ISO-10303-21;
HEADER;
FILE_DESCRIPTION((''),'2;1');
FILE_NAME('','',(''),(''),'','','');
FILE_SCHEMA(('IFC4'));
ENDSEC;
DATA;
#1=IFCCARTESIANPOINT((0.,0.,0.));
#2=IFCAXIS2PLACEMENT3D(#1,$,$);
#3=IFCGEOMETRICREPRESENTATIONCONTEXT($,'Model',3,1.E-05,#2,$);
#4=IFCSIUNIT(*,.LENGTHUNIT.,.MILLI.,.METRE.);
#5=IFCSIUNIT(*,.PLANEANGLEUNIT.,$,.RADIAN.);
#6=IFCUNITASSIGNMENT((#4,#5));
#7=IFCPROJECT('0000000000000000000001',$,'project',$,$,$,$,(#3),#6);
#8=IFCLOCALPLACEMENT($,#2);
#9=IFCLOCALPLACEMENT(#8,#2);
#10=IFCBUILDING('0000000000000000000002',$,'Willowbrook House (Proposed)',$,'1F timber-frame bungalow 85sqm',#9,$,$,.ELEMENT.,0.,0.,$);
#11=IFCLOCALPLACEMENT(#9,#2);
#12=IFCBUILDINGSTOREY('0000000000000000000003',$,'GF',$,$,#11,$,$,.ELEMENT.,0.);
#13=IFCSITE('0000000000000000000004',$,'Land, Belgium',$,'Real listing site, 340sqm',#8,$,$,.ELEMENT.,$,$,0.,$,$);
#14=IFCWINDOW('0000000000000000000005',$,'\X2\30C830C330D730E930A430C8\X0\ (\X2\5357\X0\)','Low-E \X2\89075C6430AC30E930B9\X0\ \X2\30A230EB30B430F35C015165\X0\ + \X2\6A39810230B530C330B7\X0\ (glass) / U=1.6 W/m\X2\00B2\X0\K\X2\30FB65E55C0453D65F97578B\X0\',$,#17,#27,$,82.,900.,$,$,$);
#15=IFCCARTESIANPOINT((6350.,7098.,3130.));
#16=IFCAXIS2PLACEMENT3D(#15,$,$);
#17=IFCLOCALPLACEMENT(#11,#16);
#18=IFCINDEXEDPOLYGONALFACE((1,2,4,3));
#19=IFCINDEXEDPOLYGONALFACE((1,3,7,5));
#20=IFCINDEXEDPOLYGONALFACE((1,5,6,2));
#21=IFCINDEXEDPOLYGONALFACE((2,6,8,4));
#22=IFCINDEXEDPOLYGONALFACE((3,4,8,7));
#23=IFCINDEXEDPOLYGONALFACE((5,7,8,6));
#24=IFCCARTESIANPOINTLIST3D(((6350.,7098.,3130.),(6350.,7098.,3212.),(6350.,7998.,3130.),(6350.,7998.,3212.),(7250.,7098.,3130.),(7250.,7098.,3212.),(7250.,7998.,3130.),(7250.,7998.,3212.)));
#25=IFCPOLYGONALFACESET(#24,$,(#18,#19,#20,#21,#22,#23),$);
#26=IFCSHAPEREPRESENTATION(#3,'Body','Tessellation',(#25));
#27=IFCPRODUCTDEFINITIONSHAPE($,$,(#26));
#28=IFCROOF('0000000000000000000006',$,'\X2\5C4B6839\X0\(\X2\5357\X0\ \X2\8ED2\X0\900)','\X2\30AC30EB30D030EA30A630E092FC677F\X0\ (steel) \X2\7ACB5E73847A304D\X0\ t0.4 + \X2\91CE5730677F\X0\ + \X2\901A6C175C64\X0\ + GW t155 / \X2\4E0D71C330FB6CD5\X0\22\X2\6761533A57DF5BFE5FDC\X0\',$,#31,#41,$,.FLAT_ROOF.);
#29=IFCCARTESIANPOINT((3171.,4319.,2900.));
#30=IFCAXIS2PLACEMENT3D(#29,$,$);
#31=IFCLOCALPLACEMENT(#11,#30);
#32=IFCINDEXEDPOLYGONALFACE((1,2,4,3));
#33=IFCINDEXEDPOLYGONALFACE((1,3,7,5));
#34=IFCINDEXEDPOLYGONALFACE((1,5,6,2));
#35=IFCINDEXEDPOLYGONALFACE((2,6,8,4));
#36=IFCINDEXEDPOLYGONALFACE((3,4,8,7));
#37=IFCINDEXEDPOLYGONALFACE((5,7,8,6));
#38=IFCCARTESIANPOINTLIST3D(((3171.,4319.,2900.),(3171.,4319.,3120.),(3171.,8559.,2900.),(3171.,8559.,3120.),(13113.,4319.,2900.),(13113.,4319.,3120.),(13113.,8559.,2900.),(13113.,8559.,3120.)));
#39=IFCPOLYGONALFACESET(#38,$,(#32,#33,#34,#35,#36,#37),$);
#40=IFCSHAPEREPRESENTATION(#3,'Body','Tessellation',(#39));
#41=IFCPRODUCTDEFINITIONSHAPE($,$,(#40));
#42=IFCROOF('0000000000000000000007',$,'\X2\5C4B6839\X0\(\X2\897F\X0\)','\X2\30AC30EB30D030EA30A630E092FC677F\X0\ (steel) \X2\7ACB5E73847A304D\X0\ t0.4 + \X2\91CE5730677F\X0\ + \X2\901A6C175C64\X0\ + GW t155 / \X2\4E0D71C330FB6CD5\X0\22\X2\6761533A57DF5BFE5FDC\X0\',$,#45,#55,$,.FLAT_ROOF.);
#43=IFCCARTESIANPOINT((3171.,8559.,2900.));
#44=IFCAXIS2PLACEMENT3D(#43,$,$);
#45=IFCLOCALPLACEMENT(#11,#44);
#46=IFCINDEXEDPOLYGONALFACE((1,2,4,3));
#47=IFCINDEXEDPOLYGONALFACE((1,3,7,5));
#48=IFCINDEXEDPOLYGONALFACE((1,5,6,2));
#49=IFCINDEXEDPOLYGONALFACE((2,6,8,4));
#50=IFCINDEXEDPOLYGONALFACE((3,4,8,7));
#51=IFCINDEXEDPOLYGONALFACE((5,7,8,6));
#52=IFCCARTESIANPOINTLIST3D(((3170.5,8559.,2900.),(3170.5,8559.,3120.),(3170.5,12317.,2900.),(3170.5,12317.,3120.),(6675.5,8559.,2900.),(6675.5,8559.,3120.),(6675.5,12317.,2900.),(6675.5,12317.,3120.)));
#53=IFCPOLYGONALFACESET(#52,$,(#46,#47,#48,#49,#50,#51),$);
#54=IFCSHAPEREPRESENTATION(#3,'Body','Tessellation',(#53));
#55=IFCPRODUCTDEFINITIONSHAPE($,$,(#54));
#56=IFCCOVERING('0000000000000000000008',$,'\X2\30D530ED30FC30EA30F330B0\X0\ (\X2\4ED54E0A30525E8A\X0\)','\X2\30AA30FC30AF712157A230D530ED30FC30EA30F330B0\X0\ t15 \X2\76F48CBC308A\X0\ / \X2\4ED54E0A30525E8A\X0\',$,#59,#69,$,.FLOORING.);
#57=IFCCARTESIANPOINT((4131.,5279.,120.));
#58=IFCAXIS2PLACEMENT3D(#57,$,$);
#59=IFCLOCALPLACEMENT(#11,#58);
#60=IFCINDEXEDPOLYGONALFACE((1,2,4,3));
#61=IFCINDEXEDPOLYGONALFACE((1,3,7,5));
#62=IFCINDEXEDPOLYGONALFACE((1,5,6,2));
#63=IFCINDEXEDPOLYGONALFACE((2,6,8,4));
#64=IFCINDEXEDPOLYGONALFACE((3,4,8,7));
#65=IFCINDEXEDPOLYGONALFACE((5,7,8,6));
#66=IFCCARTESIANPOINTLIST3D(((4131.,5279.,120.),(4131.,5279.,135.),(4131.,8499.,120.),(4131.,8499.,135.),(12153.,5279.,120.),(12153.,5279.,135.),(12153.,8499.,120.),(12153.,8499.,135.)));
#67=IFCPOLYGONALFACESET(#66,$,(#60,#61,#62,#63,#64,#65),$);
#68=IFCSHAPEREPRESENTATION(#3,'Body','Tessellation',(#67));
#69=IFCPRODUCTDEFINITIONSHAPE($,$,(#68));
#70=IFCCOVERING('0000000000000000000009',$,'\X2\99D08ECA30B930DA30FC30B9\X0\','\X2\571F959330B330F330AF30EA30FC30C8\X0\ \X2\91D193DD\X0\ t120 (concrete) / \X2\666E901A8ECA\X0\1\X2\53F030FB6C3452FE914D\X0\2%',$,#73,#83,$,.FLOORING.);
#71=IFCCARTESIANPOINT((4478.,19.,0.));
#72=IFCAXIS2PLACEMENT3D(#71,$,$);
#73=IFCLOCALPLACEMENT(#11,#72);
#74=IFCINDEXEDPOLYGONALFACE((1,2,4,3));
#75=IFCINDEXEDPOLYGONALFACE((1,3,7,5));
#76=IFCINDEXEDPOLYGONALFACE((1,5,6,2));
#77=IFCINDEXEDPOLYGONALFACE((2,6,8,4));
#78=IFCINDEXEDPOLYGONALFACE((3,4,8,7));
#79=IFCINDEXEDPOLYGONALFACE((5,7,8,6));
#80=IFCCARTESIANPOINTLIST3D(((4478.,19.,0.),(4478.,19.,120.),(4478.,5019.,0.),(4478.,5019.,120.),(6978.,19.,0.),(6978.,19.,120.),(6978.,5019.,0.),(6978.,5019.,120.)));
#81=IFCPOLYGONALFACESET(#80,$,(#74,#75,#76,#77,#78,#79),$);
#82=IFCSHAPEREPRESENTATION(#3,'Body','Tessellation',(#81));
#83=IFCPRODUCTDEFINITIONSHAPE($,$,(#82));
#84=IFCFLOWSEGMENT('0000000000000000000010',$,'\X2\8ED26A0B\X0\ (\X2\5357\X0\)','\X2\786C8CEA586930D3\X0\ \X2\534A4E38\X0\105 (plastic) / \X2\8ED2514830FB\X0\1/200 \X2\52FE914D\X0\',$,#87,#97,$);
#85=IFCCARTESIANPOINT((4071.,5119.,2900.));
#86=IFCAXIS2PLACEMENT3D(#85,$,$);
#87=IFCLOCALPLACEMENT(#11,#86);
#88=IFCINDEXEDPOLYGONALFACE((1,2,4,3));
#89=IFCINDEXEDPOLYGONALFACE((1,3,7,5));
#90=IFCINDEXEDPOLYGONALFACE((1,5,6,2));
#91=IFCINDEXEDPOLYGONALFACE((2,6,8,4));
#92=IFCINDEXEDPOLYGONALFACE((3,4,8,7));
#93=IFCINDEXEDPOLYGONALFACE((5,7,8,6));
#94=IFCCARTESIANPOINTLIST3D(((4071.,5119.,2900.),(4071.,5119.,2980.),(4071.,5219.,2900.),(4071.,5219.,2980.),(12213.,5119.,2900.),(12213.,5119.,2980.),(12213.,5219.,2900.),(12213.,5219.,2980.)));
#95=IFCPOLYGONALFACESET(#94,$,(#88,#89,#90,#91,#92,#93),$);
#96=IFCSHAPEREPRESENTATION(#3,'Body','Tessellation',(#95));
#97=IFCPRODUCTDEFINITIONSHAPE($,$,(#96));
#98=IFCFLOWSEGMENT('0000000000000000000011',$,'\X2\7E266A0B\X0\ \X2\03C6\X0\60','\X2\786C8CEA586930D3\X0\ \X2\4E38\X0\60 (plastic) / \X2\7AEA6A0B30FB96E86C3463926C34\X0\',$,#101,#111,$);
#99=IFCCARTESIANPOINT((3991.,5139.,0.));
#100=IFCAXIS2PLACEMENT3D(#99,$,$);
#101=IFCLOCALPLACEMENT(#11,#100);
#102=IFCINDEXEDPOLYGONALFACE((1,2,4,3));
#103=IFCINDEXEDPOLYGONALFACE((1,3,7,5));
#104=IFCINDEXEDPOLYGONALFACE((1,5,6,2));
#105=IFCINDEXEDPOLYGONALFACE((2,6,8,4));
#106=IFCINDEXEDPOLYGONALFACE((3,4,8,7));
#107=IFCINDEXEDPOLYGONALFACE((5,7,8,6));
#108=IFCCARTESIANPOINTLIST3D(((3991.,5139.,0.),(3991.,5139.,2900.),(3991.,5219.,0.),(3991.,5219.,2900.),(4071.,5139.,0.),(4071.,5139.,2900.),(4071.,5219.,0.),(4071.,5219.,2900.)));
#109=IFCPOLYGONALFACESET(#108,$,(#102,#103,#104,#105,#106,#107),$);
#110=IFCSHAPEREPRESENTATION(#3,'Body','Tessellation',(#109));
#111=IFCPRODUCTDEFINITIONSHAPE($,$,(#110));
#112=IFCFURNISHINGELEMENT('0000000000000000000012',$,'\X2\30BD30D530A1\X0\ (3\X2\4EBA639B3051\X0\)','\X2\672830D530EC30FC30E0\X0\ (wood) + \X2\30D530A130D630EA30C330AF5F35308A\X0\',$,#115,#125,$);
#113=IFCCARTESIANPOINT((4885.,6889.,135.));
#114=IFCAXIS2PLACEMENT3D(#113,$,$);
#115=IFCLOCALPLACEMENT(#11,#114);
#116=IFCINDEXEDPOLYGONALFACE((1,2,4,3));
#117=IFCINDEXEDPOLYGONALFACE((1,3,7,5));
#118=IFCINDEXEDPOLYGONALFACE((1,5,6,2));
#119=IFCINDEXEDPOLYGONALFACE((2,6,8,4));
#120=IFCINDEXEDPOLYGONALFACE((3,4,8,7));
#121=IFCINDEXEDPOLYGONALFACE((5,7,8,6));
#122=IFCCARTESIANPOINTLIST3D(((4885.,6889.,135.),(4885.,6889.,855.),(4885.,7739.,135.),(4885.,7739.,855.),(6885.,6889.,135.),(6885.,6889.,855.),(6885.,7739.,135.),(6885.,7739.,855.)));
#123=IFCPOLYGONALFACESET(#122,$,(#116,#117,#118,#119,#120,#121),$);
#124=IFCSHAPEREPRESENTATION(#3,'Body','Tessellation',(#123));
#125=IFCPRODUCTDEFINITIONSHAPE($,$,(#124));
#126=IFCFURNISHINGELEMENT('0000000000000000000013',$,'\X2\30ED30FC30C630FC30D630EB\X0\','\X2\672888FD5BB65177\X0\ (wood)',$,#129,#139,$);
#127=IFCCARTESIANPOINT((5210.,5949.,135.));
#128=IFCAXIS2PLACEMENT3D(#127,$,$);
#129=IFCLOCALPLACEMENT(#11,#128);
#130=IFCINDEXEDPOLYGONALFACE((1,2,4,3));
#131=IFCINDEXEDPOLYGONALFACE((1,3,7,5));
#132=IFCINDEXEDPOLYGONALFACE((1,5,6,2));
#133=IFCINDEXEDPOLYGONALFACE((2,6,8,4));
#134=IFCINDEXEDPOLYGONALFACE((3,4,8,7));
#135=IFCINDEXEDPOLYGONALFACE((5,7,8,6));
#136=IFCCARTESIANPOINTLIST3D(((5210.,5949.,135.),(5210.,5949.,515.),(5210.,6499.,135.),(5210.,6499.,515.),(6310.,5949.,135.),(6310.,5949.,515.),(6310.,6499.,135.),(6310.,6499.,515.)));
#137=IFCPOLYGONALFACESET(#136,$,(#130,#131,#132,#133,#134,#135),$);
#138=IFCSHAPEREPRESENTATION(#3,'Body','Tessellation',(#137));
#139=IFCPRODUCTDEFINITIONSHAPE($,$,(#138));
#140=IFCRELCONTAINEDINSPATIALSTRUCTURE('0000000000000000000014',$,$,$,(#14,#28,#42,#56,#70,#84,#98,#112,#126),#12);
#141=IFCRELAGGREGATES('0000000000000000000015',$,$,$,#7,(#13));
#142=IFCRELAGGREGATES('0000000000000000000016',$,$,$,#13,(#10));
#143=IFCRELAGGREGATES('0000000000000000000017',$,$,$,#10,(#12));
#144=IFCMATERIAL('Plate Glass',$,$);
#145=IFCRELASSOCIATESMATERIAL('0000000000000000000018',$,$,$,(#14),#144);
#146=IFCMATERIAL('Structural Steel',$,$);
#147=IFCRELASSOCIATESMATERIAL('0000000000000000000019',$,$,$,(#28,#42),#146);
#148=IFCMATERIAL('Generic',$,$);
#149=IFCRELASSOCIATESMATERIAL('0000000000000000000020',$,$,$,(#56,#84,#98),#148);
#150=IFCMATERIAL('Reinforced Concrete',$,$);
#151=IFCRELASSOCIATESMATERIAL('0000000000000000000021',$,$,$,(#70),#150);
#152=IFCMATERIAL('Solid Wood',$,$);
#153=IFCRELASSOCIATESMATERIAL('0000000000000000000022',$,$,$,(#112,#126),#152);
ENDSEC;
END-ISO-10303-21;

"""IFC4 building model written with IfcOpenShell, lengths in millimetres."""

from ifc_helpers import new_model, si_unit, frame, frame_2d, origin, place, context, project, spatial, rectangle, extrude, material, element, save


model = new_model("IFC4")

# Units and contexts
model_context = context("Model", 3, precision=1e-05, world=origin())
ifc_project = project(units=[si_unit("LENGTHUNIT", "METRE", prefix="MILLI"), si_unit("PLANEANGLEUNIT", "RADIAN")], contexts=[model_context])

# Site, building, storey
site_placement = place(None, origin())
site = spatial("IfcSite", under=ifc_project, at=site_placement, Name="Land, Belgium", ObjectType="Real listing site, 340sqm", CompositionType="ELEMENT", RefElevation=0.0)
building_placement = place(site_placement, origin())
building = spatial("IfcBuilding", under=site, at=building_placement, Name="Willowbrook House (Proposed)", ObjectType="1F timber-frame bungalow 85sqm", CompositionType="ELEMENT", ElevationOfRefHeight=0.0, ElevationOfTerrain=0.0)
storey_placement = place(building_placement, origin())
storey = spatial("IfcBuildingStorey", under=building, at=storey_placement, Name="GF", CompositionType="ELEMENT", Elevation=0.0)

# Shared definitions
ifc_material_1 = material(Name="Solid Wood")

# Shared definitions
ifc_material_2 = material(Name="Reinforced Concrete")

# Shared definitions
ifc_material_3 = material(Name="Plate Glass")

# Window
window_1_placement = place(storey_placement, frame((6350.0, 7098.0, 3130.0)))
element("IfcWindow", 1, at=window_1_placement, inside=storey, material=ifc_material_3, Name="トップライト (南)", Description="Low-E 複層ガラス アルゴン封入 + 樹脂サッシ (glass) / U=1.6 W/m²K・日射取得型", OverallHeight=82.0, OverallWidth=900.0, context=model_context, shape_type="SweptSolid", body=[
    extrude(rectangle(XDim=900.0, YDim=900.0, at=frame_2d((450.0, 450.0))), frame((6350.0, 7098.0, 3130.0)), (0.0, 0.0, 1.0), 82.0),
])

# Roofs
ifc_material_4 = material(Name="Structural Steel")
roof_1_placement = place(storey_placement, frame((3171.0, 4319.0, 2900.0)))
element("IfcRoof", 2, at=roof_1_placement, inside=storey, material=ifc_material_4, Name="屋根(南 軒900)", Description="ガルバリウム鋼板 (steel) 立平葺き t0.4 + 野地板 + 通気層 + GW t155 / 不燃・法22条区域対応", PredefinedType="FLAT_ROOF", context=model_context, shape_type="SweptSolid", body=[
    extrude(rectangle(XDim=9942.0, YDim=4240.0, at=frame_2d((4971.0, 2120.0))), frame((3171.0, 4319.0, 2900.0)), (0.0, 0.0, 1.0), 220.0),
])
roof_2_placement = place(storey_placement, frame((3171.0, 8559.0, 2900.0)))
element("IfcRoof", 3, at=roof_2_placement, inside=storey, material=ifc_material_4, Name="屋根(西)", Description="ガルバリウム鋼板 (steel) 立平葺き t0.4 + 野地板 + 通気層 + GW t155 / 不燃・法22条区域対応", PredefinedType="FLAT_ROOF", context=model_context, shape_type="SweptSolid", body=[
    extrude(rectangle(XDim=3505.0, YDim=3758.0, at=frame_2d((1752.0, 1879.0))), frame((3171.0, 8559.0, 2900.0)), (0.0, 0.0, 1.0), 220.0),
])

# Coverings
ifc_material_5 = material(Name="Generic")
covering_1_placement = place(storey_placement, frame((4131.0, 5279.0, 120.0)))
element("IfcCovering", 4, at=covering_1_placement, inside=storey, material=ifc_material_5, Name="フローリング (仕上げ床)", Description="オーク無垢フローリング t15 直貼り / 仕上げ床", PredefinedType="FLOORING", context=model_context, shape_type="SweptSolid", body=[
    extrude(rectangle(XDim=8022.0, YDim=3220.0, at=frame_2d((4011.0, 1610.0))), frame((4131.0, 5279.0, 120.0)), (0.0, 0.0, 1.0), 15.0),
])
covering_2_placement = place(storey_placement, frame((4478.0, 19.0, 0.0)))
element("IfcCovering", 5, at=covering_2_placement, inside=storey, material=ifc_material_2, Name="駐車スペース", Description="土間コンクリート 金鏝 t120 (concrete) / 普通車1台・水勾配2%", PredefinedType="FLOORING", context=model_context, shape_type="SweptSolid", body=[
    extrude(rectangle(XDim=2500.0, YDim=5000.0, at=frame_2d((1250.0, 2500.0))), frame((4478.0, 19.0, 0.0)), (0.0, 0.0, 1.0), 120.0),
])

# Flow segments
flow_segment_1_placement = place(storey_placement, frame((4071.0, 5119.0, 2900.0)))
element("IfcFlowSegment", 6, at=flow_segment_1_placement, inside=storey, material=ifc_material_5, Name="軒樋 (南)", Description="硬質塩ビ 半丸105 (plastic) / 軒先・1/200 勾配", context=model_context, shape_type="SweptSolid", body=[
    extrude(rectangle(XDim=8142.0, YDim=100.0, at=frame_2d((4071.0, 50.0))), frame((4071.0, 5119.0, 2900.0)), (0.0, 0.0, 1.0), 80.0),
])
flow_segment_2_placement = place(storey_placement, frame((3991.0, 5139.0, 0.0)))
element("IfcFlowSegment", 7, at=flow_segment_2_placement, inside=storey, material=ifc_material_5, Name="縦樋 φ60", Description="硬質塩ビ 丸60 (plastic) / 竪樋・雨水排水", context=model_context, shape_type="SweptSolid", body=[
    extrude(rectangle(XDim=80.0, YDim=80.0, at=frame_2d((40.0, 40.0))), frame((3991.0, 5139.0, 0.0)), (0.0, 0.0, 1.0), 2900.0),
])

# Furnishing elements
furnishing_1_placement = place(storey_placement, frame((4885.0, 6889.0, 135.0)))
element("IfcFurnishingElement", 8, at=furnishing_1_placement, inside=storey, material=ifc_material_1, Name="ソファ (3人掛け)", Description="木フレーム (wood) + ファブリック張り", context=model_context, shape_type="SweptSolid", body=[
    extrude(rectangle(XDim=2000.0, YDim=850.0, at=frame_2d((1000.0, 425.0))), frame((4885.0, 6889.0, 135.0)), (0.0, 0.0, 1.0), 720.0),
])
furnishing_2_placement = place(storey_placement, frame((5210.0, 5949.0, 135.0)))
element("IfcFurnishingElement", 9, at=furnishing_2_placement, inside=storey, material=ifc_material_1, Name="ローテーブル", Description="木製家具 (wood)", context=model_context, shape_type="SweptSolid", body=[
    extrude(rectangle(XDim=1100.0, YDim=550.0, at=frame_2d((550.0, 275.0))), frame((5210.0, 5949.0, 135.0)), (0.0, 0.0, 1.0), 380.0),
])

save(model, "model.ifc")
